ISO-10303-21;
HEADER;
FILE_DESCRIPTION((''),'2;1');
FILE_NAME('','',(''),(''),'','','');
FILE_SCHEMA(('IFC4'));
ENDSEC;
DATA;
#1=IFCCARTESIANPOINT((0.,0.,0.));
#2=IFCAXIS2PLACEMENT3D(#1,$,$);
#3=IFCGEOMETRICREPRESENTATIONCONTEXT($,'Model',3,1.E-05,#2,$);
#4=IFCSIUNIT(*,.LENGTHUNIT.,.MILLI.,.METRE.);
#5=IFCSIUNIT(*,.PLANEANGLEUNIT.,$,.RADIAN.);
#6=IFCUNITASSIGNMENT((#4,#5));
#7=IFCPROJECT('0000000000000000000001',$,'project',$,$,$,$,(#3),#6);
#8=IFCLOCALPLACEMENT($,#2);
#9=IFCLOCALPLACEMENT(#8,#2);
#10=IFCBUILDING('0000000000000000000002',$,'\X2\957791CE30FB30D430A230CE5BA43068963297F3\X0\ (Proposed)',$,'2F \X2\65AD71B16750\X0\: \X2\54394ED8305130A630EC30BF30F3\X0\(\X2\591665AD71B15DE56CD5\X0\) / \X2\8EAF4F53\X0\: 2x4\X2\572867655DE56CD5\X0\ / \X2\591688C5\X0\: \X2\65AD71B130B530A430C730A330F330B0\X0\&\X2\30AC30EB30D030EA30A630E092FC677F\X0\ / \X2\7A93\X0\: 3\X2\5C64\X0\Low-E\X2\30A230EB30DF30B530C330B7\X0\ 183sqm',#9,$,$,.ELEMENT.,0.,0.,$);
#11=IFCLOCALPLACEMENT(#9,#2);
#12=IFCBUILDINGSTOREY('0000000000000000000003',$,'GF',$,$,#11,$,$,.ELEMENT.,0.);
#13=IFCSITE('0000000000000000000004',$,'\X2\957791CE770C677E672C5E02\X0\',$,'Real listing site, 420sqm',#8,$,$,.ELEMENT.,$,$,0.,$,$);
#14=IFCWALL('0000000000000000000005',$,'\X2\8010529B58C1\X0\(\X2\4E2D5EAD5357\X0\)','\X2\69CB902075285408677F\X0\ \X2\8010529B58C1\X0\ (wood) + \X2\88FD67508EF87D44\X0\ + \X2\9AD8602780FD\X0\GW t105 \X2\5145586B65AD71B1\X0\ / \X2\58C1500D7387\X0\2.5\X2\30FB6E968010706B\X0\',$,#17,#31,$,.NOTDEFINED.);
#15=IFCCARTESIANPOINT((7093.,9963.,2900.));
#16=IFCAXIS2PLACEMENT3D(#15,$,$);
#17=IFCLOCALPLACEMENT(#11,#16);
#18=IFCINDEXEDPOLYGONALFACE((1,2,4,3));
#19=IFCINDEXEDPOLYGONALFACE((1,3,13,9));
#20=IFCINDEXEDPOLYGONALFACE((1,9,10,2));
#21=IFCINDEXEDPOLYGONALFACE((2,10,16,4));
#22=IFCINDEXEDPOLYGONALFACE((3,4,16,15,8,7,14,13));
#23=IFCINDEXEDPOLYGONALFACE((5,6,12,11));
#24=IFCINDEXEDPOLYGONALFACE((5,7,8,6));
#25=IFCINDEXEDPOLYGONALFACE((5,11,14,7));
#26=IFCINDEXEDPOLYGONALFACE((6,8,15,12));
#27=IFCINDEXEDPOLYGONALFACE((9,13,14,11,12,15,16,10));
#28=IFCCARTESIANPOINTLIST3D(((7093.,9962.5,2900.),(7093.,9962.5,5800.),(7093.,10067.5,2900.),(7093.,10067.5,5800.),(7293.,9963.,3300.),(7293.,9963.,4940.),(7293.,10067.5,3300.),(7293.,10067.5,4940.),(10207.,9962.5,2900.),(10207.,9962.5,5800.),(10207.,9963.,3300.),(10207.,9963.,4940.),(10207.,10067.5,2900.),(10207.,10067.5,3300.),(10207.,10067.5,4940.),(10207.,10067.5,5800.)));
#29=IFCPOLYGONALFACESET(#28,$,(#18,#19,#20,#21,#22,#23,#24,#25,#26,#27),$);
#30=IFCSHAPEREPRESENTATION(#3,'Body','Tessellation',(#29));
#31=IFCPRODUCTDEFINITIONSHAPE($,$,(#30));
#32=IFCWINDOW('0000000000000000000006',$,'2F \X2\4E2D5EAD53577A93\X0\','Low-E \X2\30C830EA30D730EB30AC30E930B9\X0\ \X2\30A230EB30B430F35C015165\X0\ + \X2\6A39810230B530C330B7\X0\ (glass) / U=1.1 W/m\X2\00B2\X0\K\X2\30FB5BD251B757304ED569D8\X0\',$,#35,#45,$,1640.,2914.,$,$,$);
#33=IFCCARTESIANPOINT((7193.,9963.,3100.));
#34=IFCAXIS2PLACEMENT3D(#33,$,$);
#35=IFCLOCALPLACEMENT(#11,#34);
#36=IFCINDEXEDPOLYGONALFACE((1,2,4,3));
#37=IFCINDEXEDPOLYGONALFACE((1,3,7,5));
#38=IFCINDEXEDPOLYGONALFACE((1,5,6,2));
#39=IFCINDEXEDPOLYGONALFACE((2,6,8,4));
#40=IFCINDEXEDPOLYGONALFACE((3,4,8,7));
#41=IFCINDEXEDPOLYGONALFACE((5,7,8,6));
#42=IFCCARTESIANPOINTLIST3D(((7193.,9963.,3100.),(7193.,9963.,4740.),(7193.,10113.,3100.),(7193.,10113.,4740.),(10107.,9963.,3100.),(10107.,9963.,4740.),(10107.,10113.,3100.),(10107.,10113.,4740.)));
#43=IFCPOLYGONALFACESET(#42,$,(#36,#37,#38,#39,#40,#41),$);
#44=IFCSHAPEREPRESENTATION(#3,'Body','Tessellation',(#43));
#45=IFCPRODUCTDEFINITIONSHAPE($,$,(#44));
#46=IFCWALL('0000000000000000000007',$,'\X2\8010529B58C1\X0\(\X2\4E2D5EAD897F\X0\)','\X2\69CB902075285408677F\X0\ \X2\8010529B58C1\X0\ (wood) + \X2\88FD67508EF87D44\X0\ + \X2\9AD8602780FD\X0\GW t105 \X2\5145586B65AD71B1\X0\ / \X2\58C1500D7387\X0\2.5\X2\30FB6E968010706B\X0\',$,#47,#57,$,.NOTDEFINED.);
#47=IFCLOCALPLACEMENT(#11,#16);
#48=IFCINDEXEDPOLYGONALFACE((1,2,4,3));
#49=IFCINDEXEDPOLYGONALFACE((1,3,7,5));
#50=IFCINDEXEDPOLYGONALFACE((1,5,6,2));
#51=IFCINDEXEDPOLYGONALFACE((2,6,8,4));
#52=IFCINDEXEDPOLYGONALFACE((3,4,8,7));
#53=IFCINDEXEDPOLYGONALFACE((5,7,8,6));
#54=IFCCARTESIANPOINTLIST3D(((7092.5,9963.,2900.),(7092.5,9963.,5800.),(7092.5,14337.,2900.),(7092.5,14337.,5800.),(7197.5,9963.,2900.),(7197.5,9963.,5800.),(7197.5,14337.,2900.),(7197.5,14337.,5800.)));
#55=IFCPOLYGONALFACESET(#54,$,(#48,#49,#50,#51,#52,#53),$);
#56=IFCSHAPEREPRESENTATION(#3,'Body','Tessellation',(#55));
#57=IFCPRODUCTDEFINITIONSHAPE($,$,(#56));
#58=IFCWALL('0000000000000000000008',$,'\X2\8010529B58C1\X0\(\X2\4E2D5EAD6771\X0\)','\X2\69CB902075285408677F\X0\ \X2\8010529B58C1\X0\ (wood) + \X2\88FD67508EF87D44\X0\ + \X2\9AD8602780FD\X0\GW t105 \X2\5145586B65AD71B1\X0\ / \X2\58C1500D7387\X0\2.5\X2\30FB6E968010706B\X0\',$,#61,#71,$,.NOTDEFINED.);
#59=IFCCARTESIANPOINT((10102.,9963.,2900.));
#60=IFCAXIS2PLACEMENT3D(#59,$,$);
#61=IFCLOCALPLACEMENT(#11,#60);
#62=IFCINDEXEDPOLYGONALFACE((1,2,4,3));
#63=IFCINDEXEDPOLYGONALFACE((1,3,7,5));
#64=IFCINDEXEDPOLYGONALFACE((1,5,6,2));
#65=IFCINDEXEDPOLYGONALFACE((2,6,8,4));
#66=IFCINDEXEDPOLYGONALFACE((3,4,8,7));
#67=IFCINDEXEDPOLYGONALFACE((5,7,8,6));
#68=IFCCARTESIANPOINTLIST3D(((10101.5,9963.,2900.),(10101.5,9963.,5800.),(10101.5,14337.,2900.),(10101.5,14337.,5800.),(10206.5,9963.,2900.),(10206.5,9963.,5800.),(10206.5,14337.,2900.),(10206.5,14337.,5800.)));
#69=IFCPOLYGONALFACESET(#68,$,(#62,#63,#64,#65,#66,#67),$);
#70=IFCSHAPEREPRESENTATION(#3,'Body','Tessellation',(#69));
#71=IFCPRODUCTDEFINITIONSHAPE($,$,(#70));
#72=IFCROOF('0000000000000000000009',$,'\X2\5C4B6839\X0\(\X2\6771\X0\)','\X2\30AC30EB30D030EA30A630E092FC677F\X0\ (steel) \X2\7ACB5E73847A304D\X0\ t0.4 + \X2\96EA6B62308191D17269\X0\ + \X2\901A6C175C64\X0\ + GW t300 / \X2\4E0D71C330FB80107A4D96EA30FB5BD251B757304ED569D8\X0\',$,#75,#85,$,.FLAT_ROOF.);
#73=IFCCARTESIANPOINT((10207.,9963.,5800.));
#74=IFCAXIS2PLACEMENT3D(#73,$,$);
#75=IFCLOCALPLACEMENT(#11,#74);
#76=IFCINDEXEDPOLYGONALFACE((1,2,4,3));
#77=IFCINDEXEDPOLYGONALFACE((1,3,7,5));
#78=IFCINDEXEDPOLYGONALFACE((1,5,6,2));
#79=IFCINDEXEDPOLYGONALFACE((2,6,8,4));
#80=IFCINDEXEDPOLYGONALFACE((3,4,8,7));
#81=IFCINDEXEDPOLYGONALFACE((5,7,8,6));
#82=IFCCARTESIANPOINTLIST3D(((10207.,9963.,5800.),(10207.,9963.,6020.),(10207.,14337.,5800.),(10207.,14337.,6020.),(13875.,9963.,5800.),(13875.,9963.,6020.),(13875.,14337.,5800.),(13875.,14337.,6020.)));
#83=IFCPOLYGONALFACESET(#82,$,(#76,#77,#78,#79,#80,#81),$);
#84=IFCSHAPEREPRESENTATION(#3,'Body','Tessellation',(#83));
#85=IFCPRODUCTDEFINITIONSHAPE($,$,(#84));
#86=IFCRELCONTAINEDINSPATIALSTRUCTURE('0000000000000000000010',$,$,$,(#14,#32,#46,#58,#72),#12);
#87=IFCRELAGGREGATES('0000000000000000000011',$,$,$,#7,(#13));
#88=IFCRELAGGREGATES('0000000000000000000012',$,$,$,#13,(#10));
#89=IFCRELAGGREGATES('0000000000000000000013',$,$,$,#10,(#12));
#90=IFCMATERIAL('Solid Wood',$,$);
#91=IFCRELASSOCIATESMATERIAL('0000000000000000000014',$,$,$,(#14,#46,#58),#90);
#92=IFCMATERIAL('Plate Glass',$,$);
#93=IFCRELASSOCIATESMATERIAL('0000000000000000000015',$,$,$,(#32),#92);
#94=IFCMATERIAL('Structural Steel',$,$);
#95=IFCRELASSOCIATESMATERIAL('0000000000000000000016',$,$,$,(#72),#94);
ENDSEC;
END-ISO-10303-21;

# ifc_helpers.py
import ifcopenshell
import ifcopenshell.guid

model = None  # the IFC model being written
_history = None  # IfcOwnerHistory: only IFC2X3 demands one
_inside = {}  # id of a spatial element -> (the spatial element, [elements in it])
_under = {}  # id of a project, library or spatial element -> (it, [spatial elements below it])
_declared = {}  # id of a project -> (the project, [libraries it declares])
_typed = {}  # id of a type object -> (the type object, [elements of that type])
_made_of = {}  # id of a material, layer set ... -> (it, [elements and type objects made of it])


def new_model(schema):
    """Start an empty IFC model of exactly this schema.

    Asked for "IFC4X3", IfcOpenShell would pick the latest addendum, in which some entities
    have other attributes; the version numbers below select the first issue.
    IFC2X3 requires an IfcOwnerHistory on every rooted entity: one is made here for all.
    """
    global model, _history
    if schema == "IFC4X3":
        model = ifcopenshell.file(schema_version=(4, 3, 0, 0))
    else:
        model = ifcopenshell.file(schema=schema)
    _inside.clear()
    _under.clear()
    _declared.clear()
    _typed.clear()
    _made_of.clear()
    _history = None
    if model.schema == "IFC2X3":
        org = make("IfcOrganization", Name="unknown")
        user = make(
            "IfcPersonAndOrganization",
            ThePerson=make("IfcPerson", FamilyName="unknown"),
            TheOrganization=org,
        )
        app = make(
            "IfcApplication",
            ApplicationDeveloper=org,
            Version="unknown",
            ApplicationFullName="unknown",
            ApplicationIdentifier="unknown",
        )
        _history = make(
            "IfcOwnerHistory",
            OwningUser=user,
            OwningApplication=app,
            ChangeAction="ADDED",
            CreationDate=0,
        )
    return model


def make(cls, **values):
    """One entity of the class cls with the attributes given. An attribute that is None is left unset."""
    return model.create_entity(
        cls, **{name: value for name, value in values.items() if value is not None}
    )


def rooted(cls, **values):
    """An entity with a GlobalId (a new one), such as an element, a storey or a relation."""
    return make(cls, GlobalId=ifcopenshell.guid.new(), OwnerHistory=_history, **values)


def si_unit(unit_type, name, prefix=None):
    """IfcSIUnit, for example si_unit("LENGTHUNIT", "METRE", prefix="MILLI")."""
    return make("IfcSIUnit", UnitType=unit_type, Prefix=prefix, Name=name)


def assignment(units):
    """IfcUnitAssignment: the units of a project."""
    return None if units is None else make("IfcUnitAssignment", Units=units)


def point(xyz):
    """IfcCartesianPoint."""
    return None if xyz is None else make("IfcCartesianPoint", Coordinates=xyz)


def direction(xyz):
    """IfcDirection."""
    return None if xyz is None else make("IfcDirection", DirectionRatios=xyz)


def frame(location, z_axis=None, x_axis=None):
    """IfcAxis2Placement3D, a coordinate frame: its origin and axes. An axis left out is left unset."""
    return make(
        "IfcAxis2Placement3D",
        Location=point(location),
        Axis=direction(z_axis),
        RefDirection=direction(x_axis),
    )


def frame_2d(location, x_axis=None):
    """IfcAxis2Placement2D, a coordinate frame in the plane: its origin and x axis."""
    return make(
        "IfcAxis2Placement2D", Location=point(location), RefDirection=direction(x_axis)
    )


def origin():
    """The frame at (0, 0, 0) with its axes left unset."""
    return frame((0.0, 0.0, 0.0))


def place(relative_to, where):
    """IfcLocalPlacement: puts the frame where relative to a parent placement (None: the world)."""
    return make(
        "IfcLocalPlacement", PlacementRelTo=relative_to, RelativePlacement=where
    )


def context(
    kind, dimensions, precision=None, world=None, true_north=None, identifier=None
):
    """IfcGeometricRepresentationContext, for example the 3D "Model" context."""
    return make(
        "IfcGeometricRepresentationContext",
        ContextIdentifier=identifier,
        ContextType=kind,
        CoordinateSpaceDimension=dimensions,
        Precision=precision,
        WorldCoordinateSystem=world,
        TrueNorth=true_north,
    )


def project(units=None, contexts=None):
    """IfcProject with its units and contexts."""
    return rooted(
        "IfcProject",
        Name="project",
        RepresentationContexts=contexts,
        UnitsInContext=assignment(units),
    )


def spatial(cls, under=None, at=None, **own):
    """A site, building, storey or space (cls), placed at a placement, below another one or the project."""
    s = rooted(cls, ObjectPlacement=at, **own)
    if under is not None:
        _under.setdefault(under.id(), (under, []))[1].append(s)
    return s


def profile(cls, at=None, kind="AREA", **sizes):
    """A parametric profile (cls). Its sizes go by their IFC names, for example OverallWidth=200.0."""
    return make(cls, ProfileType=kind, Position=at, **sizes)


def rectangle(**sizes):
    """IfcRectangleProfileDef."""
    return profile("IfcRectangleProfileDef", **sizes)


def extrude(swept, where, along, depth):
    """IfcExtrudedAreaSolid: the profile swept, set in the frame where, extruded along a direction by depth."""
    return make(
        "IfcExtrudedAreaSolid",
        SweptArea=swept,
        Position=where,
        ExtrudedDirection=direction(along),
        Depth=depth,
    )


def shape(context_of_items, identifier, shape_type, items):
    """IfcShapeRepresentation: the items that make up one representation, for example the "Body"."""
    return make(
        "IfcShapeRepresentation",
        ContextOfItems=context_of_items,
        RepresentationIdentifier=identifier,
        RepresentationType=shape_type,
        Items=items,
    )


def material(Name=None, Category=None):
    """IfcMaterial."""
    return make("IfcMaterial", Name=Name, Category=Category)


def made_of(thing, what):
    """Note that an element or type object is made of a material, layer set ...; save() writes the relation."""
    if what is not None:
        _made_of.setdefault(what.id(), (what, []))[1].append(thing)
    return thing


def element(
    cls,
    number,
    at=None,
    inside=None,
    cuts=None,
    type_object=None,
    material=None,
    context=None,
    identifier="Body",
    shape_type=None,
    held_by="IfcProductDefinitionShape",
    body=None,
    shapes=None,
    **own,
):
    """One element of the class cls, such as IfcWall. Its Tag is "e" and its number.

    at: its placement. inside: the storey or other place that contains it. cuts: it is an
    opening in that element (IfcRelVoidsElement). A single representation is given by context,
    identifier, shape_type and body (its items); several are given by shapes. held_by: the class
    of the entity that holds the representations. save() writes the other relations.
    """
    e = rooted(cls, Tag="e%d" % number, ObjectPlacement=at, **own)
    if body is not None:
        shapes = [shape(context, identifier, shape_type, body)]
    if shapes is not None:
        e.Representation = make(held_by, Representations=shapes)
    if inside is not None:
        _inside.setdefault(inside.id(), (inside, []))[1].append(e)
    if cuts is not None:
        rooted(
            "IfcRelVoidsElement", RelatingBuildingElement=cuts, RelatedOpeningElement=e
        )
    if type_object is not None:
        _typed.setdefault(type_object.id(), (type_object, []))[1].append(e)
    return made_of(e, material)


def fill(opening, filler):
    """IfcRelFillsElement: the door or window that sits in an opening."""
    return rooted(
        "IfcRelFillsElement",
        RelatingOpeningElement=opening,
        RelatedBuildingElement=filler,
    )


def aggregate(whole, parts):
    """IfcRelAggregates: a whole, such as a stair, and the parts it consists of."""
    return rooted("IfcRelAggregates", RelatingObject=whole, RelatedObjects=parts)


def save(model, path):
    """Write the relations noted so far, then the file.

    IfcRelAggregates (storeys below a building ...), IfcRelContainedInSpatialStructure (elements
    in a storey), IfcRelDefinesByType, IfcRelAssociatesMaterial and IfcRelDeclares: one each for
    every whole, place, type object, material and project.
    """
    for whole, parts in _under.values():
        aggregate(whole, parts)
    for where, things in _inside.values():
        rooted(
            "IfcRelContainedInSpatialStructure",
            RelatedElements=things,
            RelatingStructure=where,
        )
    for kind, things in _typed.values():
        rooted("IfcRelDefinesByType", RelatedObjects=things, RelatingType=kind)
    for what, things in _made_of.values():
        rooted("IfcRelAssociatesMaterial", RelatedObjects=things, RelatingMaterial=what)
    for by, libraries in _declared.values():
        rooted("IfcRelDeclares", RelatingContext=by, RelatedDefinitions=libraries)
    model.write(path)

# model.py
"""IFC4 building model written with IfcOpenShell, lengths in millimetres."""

from ifc_helpers import new_model, si_unit, frame, frame_2d, origin, place, context, project, spatial, rectangle, extrude, material, element, fill, save


model = new_model("IFC4")

# Units and contexts
model_context = context("Model", 3, precision=1e-05, world=origin())
ifc_project = project(units=[si_unit("LENGTHUNIT", "METRE", prefix="MILLI"), si_unit("PLANEANGLEUNIT", "RADIAN")], contexts=[model_context])

# Site, building, storey
site_placement = place(None, origin())
site = spatial("IfcSite", under=ifc_project, at=site_placement, Name="長野県松本市", ObjectType="Real listing site, 420sqm", CompositionType="ELEMENT", RefElevation=0.0)
building_placement = place(site_placement, origin())
building = spatial("IfcBuilding", under=site, at=building_placement, Name="長野・ピアノ室と防音 (Proposed)", ObjectType="2F 断熱材: 吹付けウレタン(外断熱工法) / 躯体: 2x4在来工法 / 外装: 断熱サイディング&ガルバリウム鋼板 / 窓: 3層Low-Eアルミサッシ 183sqm", CompositionType="ELEMENT", ElevationOfRefHeight=0.0, ElevationOfTerrain=0.0)
storey_placement = place(building_placement, origin())
storey = spatial("IfcBuildingStorey", under=building, at=storey_placement, Name="GF", CompositionType="ELEMENT", Elevation=0.0)

# Shared definitions
ifc_material_1 = material(Name="Solid Wood")

# Shared definitions
ifc_material_2 = material(Name="Plate Glass")

# Wall, opening, window
wall_1_placement = place(storey_placement, frame((7093.0, 9963.0, 2900.0)))
wall_1 = element("IfcWall", 1, at=wall_1_placement, inside=storey, material=ifc_material_1, Name="耐力壁(中庭南)", Description="構造用合板 耐力壁 (wood) + 製材軸組 + 高性能GW t105 充填断熱 / 壁倍率2.5・準耐火", PredefinedType="NOTDEFINED", context=model_context, shape_type="SweptSolid", body=[
    extrude(rectangle(XDim=3114.0, YDim=105.0, at=frame_2d((1557.0, 52.0))), frame((7093.0, 9963.0, 2900.0)), (0.0, 0.0, 1.0), 2900.0),
])
opening_1_placement = place(storey_placement, frame((7193.0, 9963.0, 3100.0)))
opening_1 = element("IfcOpeningElement", 2, at=opening_1_placement, cuts=wall_1, PredefinedType="NOTDEFINED", context=model_context, shape_type="SweptSolid", body=[
    extrude(rectangle(XDim=2914.0, YDim=150.0, at=frame_2d((1457.0, 75.0))), frame((7193.0, 9963.0, 3100.0)), (0.0, 0.0, 1.0), 1640.0),
])
window_1_placement = place(storey_placement, frame((7193.0, 9963.0, 3100.0)))
window_1 = element("IfcWindow", 3, at=window_1_placement, inside=storey, material=ifc_material_2, Name="2F 中庭南窓", Description="Low-E トリプルガラス アルゴン封入 + 樹脂サッシ (glass) / U=1.1 W/m²K・寒冷地仕様", OverallHeight=1640.0, OverallWidth=2914.0, context=model_context, shape_type="SweptSolid", body=[
    extrude(rectangle(XDim=2914.0, YDim=150.0, at=frame_2d((1457.0, 75.0))), frame((7193.0, 9963.0, 3100.0)), (0.0, 0.0, 1.0), 1640.0),
])
fill(opening_1, window_1)

# Walls
wall_2_placement = place(storey_placement, frame((7093.0, 9963.0, 2900.0)))
element("IfcWall", 4, at=wall_2_placement, inside=storey, material=ifc_material_1, Name="耐力壁(中庭西)", Description="構造用合板 耐力壁 (wood) + 製材軸組 + 高性能GW t105 充填断熱 / 壁倍率2.5・準耐火", PredefinedType="NOTDEFINED", context=model_context, shape_type="SweptSolid", body=[
    extrude(rectangle(XDim=105.0, YDim=4374.0, at=frame_2d((52.0, 2187.0))), frame((7093.0, 9963.0, 2900.0)), (0.0, 0.0, 1.0), 2900.0),
])
wall_3_placement = place(storey_placement, frame((10102.0, 9963.0, 2900.0)))
element("IfcWall", 5, at=wall_3_placement, inside=storey, material=ifc_material_1, Name="耐力壁(中庭東)", Description="構造用合板 耐力壁 (wood) + 製材軸組 + 高性能GW t105 充填断熱 / 壁倍率2.5・準耐火", PredefinedType="NOTDEFINED", context=model_context, shape_type="SweptSolid", body=[
    extrude(rectangle(XDim=105.0, YDim=4374.0, at=frame_2d((52.0, 2187.0))), frame((10102.0, 9963.0, 2900.0)), (0.0, 0.0, 1.0), 2900.0),
])

# Roof
ifc_material_3 = material(Name="Structural Steel")
for number, where, name in (
    (6, (10207.0, 9963.0, 5800.0), "屋根(東)"),
):
    element("IfcRoof", number, at=place(storey_placement, frame(where)), inside=storey, material=ifc_material_3, Name=name, Description="ガルバリウム鋼板 (steel) 立平葺き t0.4 + 雪止め金物 + 通気層 + GW t300 / 不燃・耐積雪・寒冷地仕様", PredefinedType="FLAT_ROOF", context=model_context, shape_type="SweptSolid", body=[
        extrude(rectangle(XDim=3668.0, YDim=4374.0, at=frame_2d((1834.0, 2187.0))), frame((10207.0, 9963.0, 5800.0)), (0.0, 0.0, 1.0), 220.0),
    ])

save(model, "model.ifc")
